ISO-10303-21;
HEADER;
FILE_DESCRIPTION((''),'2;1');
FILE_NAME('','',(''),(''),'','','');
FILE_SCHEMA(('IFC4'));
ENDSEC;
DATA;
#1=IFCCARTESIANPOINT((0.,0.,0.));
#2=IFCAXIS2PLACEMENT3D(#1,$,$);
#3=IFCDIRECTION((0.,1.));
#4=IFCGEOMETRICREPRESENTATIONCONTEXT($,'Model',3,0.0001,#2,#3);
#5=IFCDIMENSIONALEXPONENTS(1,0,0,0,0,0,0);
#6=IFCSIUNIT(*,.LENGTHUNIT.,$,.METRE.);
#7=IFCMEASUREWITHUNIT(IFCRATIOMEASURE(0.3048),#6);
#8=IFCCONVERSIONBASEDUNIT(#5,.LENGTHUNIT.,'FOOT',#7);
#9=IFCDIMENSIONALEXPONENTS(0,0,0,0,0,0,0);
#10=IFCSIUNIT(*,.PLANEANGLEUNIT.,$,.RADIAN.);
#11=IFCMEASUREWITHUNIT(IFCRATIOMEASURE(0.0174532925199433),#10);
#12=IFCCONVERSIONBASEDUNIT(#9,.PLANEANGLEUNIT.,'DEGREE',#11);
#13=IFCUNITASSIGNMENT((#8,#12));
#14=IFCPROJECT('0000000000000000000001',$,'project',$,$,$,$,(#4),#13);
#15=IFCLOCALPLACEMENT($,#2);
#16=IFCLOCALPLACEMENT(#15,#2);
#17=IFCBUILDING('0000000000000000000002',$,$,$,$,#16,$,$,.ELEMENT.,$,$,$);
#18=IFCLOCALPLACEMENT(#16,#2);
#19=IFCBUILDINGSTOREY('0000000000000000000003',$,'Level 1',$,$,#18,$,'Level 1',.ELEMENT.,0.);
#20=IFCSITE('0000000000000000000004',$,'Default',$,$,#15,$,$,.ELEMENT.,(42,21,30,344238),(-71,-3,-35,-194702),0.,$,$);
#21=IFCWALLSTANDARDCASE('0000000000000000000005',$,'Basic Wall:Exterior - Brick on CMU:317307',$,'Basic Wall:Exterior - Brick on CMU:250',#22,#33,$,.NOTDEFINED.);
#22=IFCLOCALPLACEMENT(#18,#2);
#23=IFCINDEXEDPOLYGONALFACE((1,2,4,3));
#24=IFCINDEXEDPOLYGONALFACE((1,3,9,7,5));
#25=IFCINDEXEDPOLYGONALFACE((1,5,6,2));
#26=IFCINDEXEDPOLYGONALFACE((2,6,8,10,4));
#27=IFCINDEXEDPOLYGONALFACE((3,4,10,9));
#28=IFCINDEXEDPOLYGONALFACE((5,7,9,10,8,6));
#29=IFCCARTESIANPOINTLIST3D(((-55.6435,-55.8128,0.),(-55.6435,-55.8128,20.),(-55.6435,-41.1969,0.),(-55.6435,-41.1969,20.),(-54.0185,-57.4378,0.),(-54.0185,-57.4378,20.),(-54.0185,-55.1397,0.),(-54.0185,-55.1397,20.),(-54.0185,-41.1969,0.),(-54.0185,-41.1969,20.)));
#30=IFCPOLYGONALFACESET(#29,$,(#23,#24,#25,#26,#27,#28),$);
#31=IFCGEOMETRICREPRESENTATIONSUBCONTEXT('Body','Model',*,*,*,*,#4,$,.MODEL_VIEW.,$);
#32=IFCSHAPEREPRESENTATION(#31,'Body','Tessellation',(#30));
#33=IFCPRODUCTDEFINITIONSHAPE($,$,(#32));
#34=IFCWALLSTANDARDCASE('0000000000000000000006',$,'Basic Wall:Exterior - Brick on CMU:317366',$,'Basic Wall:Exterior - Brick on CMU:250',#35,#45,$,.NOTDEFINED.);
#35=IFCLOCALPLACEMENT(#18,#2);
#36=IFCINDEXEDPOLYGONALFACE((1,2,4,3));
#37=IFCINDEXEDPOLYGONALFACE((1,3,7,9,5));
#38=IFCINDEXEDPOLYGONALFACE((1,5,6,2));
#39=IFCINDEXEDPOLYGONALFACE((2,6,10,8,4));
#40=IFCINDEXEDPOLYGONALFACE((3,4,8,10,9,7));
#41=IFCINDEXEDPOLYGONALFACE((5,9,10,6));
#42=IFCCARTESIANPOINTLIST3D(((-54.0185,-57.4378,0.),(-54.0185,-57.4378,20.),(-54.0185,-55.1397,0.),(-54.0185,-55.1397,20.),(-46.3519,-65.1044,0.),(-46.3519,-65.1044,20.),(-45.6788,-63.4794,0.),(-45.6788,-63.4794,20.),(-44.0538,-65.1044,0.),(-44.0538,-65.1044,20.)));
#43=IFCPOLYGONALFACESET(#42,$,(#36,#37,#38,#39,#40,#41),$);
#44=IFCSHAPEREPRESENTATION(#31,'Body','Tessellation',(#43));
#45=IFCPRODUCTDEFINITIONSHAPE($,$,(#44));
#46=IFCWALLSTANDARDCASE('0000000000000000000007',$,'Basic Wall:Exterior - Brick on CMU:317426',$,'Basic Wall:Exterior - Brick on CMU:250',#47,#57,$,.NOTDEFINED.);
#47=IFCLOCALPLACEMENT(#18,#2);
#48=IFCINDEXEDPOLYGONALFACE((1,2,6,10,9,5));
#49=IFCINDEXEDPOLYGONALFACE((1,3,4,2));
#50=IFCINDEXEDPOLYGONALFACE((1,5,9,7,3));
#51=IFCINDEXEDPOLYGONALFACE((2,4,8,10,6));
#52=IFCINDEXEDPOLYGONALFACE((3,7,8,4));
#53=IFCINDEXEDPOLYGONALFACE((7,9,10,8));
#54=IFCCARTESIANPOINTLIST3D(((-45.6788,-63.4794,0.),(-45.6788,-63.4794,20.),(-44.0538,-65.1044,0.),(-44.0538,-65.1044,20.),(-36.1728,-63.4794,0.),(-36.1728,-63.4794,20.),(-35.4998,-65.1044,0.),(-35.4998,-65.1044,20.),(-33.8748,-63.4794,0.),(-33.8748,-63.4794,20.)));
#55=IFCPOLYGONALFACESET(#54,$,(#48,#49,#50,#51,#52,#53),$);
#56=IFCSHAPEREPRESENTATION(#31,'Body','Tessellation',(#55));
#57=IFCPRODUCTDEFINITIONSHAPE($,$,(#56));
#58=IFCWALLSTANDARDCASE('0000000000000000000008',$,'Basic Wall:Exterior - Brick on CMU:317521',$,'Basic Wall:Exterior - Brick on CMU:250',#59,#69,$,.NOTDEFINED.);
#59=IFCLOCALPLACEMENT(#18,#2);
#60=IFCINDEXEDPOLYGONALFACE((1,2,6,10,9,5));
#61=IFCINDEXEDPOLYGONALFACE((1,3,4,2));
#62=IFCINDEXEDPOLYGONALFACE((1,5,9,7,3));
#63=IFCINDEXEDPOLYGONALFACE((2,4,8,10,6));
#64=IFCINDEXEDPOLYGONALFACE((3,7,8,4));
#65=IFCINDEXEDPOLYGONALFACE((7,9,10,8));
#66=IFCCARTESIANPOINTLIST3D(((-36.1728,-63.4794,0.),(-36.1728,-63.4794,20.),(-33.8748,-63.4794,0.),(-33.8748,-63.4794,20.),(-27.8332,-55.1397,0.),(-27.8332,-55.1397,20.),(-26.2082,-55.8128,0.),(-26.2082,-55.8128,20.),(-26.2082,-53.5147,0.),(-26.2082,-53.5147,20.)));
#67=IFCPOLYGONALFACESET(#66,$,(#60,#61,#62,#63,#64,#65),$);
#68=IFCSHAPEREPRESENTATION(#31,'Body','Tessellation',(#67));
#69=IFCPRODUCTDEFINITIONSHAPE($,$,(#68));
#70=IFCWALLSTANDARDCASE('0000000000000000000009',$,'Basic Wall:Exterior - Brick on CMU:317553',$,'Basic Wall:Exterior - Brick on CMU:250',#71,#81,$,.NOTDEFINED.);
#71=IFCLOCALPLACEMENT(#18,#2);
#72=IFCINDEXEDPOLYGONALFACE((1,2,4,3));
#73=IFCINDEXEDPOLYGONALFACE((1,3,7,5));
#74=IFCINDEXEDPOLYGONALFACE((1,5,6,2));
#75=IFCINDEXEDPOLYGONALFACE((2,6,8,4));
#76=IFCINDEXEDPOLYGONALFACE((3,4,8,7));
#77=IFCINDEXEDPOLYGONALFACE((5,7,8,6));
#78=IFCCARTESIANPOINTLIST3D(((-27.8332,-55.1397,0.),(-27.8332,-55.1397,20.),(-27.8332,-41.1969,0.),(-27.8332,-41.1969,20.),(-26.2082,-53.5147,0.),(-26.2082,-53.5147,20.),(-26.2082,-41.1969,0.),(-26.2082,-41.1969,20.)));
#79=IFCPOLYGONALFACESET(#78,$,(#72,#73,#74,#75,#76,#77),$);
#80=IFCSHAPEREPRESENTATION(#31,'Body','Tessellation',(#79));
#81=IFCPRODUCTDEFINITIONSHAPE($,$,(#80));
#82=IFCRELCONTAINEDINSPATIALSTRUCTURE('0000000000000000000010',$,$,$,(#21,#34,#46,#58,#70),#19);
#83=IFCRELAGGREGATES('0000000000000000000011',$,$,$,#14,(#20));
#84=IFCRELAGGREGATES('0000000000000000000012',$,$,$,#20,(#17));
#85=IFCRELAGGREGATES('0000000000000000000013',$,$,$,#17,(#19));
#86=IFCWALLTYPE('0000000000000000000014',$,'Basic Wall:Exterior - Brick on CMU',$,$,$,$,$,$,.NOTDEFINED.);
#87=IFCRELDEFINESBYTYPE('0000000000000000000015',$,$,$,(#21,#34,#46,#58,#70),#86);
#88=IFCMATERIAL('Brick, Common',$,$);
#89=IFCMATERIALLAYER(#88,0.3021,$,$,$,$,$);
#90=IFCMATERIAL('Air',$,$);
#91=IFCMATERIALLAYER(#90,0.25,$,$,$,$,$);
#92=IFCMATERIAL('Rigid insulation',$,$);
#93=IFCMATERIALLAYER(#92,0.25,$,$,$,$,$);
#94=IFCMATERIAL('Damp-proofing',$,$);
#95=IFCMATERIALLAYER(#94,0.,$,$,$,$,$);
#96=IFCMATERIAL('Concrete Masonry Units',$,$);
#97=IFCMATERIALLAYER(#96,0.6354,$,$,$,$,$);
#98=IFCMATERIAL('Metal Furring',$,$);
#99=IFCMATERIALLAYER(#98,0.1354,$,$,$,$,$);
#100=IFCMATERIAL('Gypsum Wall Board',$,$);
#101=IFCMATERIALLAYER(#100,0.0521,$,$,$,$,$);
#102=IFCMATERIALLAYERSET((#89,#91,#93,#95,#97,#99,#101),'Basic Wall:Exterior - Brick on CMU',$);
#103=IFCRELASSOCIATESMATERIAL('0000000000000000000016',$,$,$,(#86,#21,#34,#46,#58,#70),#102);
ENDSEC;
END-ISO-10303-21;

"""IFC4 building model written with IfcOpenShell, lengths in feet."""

from ifc_helpers import new_model, entity, si_unit, converted_unit, direction, frame, origin, place, context, subcontext, project, spatial, polyline, outline, extrude, material, layer, layer_set, layer_usage, type_object, element, save


model = new_model("IFC4")

# Units and contexts
model_context = context("Model", 3, precision=0.0001, world=origin(), true_north=direction((0.0, 1.0)))
body_context = subcontext(model_context, "Body", "Model", "MODEL_VIEW")
ifc_project = project(units=[converted_unit("LENGTHUNIT", "FOOT", entity("IfcRatioMeasure", 0.3048), si_unit("LENGTHUNIT", "METRE"), dimensions=[1, 0, 0, 0, 0, 0, 0]), converted_unit("PLANEANGLEUNIT", "DEGREE", entity("IfcRatioMeasure", 0.0174532925199433), si_unit("PLANEANGLEUNIT", "RADIAN"), dimensions=[0, 0, 0, 0, 0, 0, 0])], contexts=[model_context])

# Site, building, storey
site_placement = place(None, origin())
site = spatial("IfcSite", under=ifc_project, at=site_placement, Name="Default", CompositionType="ELEMENT", RefLatitude=(42, 21, 30, 344238), RefLongitude=(-71, -3, -35, -194702), RefElevation=0.0)
building_placement = place(site_placement, origin())
building = spatial("IfcBuilding", under=site, at=building_placement, CompositionType="ELEMENT")
storey_placement = place(building_placement, origin())
storey = spatial("IfcBuildingStorey", under=building, at=storey_placement, Name="Level 1", LongName="Level 1", CompositionType="ELEMENT", Elevation=0.0)

# Walls
ifc_material_1 = material(Name="Brick, Common")
ifc_layer_1 = layer(ifc_material_1, 0.3021)
ifc_material_2 = material(Name="Air")
ifc_layer_2 = layer(ifc_material_2, 0.25)
ifc_material_3 = material(Name="Rigid insulation")
ifc_layer_3 = layer(ifc_material_3, 0.25)
ifc_material_4 = material(Name="Damp-proofing")
ifc_layer_4 = layer(ifc_material_4, 0.0)
ifc_material_5 = material(Name="Concrete Masonry Units")
ifc_layer_5 = layer(ifc_material_5, 0.6354)
ifc_material_6 = material(Name="Metal Furring")
ifc_layer_6 = layer(ifc_material_6, 0.1354)
ifc_material_7 = material(Name="Gypsum Wall Board")
ifc_layer_7 = layer(ifc_material_7, 0.0521)
ifc_layer_set = layer_set([ifc_layer_1, ifc_layer_2, ifc_layer_3, ifc_layer_4, ifc_layer_5, ifc_layer_6, ifc_layer_7], Name="Basic Wall:Exterior - Brick on CMU")
ifc_layer_usage_1 = layer_usage(ifc_layer_set, "AXIS2", "NEGATIVE", 0.8125)
wall_type = type_object("IfcWallType", Name="Basic Wall:Exterior - Brick on CMU", PredefinedType="NOTDEFINED", material=ifc_layer_set)
wall_1_placement = place(storey_placement, frame((-54.831, -41.1969, 0.0), z_axis=(0.0, 0.0, 1.0), x_axis=(0.0, -1.0, 0.0)))
element("IfcWallStandardCase", 1, at=wall_1_placement, inside=storey, type_object=wall_type, material=ifc_layer_usage_1, Name="Basic Wall:Exterior - Brick on CMU:317307", ObjectType="Basic Wall:Exterior - Brick on CMU:250", PredefinedType="NOTDEFINED", context=body_context, shape_type="SweptSolid", body=[
    extrude(outline(polyline([(14.6159, -0.8125), (16.2409, 0.8125), (13.9428, 0.8125), (0.0, 0.8125), (0.0, -0.8125), (14.6159, -0.8125)])), origin(), (0.0, 0.0, 1.0), 20.0),
])
ifc_layer_usage_2 = layer_usage(ifc_layer_set, "AXIS2", "NEGATIVE", 0.8125)
wall_2_placement = place(storey_placement, frame((-44.6283, -65.6789, 0.0), z_axis=(0.0, 0.0, 1.0), x_axis=(-0.707107, 0.707107, 0.0)))
element("IfcWallStandardCase", 2, at=wall_2_placement, inside=storey, type_object=wall_type, material=ifc_layer_usage_2, Name="Basic Wall:Exterior - Brick on CMU:317366", ObjectType="Basic Wall:Exterior - Brick on CMU:250", PredefinedType="NOTDEFINED", context=body_context, shape_type="SweptSolid", body=[
    extrude(outline(polyline([(14.0922, -0.8125), (12.4672, 0.8125), (1.625, 0.8125), (0.0, -0.8125), (2.2981, -0.8125), (14.0922, -0.8125)])), origin(), (0.0, 0.0, 1.0), 20.0),
])
ifc_layer_usage_3 = layer_usage(ifc_layer_set, "AXIS2", "NEGATIVE", 0.8125)
wall_3_placement = place(storey_placement, frame((-33.8748, -64.2919, 0.0), z_axis=(0.0, 0.0, 1.0), x_axis=(-1.0, 0.0, 0.0)))
element("IfcWallStandardCase", 3, at=wall_3_placement, inside=storey, type_object=wall_type, material=ifc_layer_usage_3, Name="Basic Wall:Exterior - Brick on CMU:317426", ObjectType="Basic Wall:Exterior - Brick on CMU:250", PredefinedType="NOTDEFINED", context=body_context, shape_type="SweptSolid", body=[
    extrude(outline(polyline([(11.8041, -0.8125), (10.1791, 0.8125), (1.625, 0.8125), (0.0, -0.8125), (2.2981, -0.8125), (11.8041, -0.8125)])), origin(), (0.0, 0.0, 1.0), 20.0),
])
ifc_layer_usage_4 = layer_usage(ifc_layer_set, "AXIS2", "POSITIVE", -0.8125)
wall_4_placement = place(storey_placement, frame((-35.5983, -64.0539, 0.0), z_axis=(0.0, 0.0, 1.0), x_axis=(0.707107, 0.707107, 0.0)))
element("IfcWallStandardCase", 4, at=wall_4_placement, inside=storey, type_object=wall_type, material=ifc_layer_usage_4, Name="Basic Wall:Exterior - Brick on CMU:317521", ObjectType="Basic Wall:Exterior - Brick on CMU:250", PredefinedType="NOTDEFINED", context=body_context, shape_type="SweptSolid", body=[
    extrude(outline(polyline([(12.4672, -0.8125), (14.0922, 0.8125), (11.7941, 0.8125), (0.0, 0.8125), (1.625, -0.8125), (12.4672, -0.8125)])), origin(), (0.0, 0.0, 1.0), 20.0),
])
ifc_layer_usage_5 = layer_usage(ifc_layer_set, "AXIS2", "POSITIVE", -0.8125)
wall_5_placement = place(storey_placement, frame((-27.0207, -41.1969, 0.0), z_axis=(0.0, 0.0, 1.0), x_axis=(0.0, -1.0, 0.0)))
element("IfcWallStandardCase", 5, at=wall_5_placement, inside=storey, type_object=wall_type, material=ifc_layer_usage_5, Name="Basic Wall:Exterior - Brick on CMU:317553", ObjectType="Basic Wall:Exterior - Brick on CMU:250", PredefinedType="NOTDEFINED", context=body_context, shape_type="SweptSolid", body=[
    extrude(outline(polyline([(13.9428, -0.8125), (12.3178, 0.8125), (0.0, 0.8125), (0.0, -0.8125), (13.9428, -0.8125)])), origin(), (0.0, 0.0, 1.0), 20.0),
])

save(model, "model.ifc")
